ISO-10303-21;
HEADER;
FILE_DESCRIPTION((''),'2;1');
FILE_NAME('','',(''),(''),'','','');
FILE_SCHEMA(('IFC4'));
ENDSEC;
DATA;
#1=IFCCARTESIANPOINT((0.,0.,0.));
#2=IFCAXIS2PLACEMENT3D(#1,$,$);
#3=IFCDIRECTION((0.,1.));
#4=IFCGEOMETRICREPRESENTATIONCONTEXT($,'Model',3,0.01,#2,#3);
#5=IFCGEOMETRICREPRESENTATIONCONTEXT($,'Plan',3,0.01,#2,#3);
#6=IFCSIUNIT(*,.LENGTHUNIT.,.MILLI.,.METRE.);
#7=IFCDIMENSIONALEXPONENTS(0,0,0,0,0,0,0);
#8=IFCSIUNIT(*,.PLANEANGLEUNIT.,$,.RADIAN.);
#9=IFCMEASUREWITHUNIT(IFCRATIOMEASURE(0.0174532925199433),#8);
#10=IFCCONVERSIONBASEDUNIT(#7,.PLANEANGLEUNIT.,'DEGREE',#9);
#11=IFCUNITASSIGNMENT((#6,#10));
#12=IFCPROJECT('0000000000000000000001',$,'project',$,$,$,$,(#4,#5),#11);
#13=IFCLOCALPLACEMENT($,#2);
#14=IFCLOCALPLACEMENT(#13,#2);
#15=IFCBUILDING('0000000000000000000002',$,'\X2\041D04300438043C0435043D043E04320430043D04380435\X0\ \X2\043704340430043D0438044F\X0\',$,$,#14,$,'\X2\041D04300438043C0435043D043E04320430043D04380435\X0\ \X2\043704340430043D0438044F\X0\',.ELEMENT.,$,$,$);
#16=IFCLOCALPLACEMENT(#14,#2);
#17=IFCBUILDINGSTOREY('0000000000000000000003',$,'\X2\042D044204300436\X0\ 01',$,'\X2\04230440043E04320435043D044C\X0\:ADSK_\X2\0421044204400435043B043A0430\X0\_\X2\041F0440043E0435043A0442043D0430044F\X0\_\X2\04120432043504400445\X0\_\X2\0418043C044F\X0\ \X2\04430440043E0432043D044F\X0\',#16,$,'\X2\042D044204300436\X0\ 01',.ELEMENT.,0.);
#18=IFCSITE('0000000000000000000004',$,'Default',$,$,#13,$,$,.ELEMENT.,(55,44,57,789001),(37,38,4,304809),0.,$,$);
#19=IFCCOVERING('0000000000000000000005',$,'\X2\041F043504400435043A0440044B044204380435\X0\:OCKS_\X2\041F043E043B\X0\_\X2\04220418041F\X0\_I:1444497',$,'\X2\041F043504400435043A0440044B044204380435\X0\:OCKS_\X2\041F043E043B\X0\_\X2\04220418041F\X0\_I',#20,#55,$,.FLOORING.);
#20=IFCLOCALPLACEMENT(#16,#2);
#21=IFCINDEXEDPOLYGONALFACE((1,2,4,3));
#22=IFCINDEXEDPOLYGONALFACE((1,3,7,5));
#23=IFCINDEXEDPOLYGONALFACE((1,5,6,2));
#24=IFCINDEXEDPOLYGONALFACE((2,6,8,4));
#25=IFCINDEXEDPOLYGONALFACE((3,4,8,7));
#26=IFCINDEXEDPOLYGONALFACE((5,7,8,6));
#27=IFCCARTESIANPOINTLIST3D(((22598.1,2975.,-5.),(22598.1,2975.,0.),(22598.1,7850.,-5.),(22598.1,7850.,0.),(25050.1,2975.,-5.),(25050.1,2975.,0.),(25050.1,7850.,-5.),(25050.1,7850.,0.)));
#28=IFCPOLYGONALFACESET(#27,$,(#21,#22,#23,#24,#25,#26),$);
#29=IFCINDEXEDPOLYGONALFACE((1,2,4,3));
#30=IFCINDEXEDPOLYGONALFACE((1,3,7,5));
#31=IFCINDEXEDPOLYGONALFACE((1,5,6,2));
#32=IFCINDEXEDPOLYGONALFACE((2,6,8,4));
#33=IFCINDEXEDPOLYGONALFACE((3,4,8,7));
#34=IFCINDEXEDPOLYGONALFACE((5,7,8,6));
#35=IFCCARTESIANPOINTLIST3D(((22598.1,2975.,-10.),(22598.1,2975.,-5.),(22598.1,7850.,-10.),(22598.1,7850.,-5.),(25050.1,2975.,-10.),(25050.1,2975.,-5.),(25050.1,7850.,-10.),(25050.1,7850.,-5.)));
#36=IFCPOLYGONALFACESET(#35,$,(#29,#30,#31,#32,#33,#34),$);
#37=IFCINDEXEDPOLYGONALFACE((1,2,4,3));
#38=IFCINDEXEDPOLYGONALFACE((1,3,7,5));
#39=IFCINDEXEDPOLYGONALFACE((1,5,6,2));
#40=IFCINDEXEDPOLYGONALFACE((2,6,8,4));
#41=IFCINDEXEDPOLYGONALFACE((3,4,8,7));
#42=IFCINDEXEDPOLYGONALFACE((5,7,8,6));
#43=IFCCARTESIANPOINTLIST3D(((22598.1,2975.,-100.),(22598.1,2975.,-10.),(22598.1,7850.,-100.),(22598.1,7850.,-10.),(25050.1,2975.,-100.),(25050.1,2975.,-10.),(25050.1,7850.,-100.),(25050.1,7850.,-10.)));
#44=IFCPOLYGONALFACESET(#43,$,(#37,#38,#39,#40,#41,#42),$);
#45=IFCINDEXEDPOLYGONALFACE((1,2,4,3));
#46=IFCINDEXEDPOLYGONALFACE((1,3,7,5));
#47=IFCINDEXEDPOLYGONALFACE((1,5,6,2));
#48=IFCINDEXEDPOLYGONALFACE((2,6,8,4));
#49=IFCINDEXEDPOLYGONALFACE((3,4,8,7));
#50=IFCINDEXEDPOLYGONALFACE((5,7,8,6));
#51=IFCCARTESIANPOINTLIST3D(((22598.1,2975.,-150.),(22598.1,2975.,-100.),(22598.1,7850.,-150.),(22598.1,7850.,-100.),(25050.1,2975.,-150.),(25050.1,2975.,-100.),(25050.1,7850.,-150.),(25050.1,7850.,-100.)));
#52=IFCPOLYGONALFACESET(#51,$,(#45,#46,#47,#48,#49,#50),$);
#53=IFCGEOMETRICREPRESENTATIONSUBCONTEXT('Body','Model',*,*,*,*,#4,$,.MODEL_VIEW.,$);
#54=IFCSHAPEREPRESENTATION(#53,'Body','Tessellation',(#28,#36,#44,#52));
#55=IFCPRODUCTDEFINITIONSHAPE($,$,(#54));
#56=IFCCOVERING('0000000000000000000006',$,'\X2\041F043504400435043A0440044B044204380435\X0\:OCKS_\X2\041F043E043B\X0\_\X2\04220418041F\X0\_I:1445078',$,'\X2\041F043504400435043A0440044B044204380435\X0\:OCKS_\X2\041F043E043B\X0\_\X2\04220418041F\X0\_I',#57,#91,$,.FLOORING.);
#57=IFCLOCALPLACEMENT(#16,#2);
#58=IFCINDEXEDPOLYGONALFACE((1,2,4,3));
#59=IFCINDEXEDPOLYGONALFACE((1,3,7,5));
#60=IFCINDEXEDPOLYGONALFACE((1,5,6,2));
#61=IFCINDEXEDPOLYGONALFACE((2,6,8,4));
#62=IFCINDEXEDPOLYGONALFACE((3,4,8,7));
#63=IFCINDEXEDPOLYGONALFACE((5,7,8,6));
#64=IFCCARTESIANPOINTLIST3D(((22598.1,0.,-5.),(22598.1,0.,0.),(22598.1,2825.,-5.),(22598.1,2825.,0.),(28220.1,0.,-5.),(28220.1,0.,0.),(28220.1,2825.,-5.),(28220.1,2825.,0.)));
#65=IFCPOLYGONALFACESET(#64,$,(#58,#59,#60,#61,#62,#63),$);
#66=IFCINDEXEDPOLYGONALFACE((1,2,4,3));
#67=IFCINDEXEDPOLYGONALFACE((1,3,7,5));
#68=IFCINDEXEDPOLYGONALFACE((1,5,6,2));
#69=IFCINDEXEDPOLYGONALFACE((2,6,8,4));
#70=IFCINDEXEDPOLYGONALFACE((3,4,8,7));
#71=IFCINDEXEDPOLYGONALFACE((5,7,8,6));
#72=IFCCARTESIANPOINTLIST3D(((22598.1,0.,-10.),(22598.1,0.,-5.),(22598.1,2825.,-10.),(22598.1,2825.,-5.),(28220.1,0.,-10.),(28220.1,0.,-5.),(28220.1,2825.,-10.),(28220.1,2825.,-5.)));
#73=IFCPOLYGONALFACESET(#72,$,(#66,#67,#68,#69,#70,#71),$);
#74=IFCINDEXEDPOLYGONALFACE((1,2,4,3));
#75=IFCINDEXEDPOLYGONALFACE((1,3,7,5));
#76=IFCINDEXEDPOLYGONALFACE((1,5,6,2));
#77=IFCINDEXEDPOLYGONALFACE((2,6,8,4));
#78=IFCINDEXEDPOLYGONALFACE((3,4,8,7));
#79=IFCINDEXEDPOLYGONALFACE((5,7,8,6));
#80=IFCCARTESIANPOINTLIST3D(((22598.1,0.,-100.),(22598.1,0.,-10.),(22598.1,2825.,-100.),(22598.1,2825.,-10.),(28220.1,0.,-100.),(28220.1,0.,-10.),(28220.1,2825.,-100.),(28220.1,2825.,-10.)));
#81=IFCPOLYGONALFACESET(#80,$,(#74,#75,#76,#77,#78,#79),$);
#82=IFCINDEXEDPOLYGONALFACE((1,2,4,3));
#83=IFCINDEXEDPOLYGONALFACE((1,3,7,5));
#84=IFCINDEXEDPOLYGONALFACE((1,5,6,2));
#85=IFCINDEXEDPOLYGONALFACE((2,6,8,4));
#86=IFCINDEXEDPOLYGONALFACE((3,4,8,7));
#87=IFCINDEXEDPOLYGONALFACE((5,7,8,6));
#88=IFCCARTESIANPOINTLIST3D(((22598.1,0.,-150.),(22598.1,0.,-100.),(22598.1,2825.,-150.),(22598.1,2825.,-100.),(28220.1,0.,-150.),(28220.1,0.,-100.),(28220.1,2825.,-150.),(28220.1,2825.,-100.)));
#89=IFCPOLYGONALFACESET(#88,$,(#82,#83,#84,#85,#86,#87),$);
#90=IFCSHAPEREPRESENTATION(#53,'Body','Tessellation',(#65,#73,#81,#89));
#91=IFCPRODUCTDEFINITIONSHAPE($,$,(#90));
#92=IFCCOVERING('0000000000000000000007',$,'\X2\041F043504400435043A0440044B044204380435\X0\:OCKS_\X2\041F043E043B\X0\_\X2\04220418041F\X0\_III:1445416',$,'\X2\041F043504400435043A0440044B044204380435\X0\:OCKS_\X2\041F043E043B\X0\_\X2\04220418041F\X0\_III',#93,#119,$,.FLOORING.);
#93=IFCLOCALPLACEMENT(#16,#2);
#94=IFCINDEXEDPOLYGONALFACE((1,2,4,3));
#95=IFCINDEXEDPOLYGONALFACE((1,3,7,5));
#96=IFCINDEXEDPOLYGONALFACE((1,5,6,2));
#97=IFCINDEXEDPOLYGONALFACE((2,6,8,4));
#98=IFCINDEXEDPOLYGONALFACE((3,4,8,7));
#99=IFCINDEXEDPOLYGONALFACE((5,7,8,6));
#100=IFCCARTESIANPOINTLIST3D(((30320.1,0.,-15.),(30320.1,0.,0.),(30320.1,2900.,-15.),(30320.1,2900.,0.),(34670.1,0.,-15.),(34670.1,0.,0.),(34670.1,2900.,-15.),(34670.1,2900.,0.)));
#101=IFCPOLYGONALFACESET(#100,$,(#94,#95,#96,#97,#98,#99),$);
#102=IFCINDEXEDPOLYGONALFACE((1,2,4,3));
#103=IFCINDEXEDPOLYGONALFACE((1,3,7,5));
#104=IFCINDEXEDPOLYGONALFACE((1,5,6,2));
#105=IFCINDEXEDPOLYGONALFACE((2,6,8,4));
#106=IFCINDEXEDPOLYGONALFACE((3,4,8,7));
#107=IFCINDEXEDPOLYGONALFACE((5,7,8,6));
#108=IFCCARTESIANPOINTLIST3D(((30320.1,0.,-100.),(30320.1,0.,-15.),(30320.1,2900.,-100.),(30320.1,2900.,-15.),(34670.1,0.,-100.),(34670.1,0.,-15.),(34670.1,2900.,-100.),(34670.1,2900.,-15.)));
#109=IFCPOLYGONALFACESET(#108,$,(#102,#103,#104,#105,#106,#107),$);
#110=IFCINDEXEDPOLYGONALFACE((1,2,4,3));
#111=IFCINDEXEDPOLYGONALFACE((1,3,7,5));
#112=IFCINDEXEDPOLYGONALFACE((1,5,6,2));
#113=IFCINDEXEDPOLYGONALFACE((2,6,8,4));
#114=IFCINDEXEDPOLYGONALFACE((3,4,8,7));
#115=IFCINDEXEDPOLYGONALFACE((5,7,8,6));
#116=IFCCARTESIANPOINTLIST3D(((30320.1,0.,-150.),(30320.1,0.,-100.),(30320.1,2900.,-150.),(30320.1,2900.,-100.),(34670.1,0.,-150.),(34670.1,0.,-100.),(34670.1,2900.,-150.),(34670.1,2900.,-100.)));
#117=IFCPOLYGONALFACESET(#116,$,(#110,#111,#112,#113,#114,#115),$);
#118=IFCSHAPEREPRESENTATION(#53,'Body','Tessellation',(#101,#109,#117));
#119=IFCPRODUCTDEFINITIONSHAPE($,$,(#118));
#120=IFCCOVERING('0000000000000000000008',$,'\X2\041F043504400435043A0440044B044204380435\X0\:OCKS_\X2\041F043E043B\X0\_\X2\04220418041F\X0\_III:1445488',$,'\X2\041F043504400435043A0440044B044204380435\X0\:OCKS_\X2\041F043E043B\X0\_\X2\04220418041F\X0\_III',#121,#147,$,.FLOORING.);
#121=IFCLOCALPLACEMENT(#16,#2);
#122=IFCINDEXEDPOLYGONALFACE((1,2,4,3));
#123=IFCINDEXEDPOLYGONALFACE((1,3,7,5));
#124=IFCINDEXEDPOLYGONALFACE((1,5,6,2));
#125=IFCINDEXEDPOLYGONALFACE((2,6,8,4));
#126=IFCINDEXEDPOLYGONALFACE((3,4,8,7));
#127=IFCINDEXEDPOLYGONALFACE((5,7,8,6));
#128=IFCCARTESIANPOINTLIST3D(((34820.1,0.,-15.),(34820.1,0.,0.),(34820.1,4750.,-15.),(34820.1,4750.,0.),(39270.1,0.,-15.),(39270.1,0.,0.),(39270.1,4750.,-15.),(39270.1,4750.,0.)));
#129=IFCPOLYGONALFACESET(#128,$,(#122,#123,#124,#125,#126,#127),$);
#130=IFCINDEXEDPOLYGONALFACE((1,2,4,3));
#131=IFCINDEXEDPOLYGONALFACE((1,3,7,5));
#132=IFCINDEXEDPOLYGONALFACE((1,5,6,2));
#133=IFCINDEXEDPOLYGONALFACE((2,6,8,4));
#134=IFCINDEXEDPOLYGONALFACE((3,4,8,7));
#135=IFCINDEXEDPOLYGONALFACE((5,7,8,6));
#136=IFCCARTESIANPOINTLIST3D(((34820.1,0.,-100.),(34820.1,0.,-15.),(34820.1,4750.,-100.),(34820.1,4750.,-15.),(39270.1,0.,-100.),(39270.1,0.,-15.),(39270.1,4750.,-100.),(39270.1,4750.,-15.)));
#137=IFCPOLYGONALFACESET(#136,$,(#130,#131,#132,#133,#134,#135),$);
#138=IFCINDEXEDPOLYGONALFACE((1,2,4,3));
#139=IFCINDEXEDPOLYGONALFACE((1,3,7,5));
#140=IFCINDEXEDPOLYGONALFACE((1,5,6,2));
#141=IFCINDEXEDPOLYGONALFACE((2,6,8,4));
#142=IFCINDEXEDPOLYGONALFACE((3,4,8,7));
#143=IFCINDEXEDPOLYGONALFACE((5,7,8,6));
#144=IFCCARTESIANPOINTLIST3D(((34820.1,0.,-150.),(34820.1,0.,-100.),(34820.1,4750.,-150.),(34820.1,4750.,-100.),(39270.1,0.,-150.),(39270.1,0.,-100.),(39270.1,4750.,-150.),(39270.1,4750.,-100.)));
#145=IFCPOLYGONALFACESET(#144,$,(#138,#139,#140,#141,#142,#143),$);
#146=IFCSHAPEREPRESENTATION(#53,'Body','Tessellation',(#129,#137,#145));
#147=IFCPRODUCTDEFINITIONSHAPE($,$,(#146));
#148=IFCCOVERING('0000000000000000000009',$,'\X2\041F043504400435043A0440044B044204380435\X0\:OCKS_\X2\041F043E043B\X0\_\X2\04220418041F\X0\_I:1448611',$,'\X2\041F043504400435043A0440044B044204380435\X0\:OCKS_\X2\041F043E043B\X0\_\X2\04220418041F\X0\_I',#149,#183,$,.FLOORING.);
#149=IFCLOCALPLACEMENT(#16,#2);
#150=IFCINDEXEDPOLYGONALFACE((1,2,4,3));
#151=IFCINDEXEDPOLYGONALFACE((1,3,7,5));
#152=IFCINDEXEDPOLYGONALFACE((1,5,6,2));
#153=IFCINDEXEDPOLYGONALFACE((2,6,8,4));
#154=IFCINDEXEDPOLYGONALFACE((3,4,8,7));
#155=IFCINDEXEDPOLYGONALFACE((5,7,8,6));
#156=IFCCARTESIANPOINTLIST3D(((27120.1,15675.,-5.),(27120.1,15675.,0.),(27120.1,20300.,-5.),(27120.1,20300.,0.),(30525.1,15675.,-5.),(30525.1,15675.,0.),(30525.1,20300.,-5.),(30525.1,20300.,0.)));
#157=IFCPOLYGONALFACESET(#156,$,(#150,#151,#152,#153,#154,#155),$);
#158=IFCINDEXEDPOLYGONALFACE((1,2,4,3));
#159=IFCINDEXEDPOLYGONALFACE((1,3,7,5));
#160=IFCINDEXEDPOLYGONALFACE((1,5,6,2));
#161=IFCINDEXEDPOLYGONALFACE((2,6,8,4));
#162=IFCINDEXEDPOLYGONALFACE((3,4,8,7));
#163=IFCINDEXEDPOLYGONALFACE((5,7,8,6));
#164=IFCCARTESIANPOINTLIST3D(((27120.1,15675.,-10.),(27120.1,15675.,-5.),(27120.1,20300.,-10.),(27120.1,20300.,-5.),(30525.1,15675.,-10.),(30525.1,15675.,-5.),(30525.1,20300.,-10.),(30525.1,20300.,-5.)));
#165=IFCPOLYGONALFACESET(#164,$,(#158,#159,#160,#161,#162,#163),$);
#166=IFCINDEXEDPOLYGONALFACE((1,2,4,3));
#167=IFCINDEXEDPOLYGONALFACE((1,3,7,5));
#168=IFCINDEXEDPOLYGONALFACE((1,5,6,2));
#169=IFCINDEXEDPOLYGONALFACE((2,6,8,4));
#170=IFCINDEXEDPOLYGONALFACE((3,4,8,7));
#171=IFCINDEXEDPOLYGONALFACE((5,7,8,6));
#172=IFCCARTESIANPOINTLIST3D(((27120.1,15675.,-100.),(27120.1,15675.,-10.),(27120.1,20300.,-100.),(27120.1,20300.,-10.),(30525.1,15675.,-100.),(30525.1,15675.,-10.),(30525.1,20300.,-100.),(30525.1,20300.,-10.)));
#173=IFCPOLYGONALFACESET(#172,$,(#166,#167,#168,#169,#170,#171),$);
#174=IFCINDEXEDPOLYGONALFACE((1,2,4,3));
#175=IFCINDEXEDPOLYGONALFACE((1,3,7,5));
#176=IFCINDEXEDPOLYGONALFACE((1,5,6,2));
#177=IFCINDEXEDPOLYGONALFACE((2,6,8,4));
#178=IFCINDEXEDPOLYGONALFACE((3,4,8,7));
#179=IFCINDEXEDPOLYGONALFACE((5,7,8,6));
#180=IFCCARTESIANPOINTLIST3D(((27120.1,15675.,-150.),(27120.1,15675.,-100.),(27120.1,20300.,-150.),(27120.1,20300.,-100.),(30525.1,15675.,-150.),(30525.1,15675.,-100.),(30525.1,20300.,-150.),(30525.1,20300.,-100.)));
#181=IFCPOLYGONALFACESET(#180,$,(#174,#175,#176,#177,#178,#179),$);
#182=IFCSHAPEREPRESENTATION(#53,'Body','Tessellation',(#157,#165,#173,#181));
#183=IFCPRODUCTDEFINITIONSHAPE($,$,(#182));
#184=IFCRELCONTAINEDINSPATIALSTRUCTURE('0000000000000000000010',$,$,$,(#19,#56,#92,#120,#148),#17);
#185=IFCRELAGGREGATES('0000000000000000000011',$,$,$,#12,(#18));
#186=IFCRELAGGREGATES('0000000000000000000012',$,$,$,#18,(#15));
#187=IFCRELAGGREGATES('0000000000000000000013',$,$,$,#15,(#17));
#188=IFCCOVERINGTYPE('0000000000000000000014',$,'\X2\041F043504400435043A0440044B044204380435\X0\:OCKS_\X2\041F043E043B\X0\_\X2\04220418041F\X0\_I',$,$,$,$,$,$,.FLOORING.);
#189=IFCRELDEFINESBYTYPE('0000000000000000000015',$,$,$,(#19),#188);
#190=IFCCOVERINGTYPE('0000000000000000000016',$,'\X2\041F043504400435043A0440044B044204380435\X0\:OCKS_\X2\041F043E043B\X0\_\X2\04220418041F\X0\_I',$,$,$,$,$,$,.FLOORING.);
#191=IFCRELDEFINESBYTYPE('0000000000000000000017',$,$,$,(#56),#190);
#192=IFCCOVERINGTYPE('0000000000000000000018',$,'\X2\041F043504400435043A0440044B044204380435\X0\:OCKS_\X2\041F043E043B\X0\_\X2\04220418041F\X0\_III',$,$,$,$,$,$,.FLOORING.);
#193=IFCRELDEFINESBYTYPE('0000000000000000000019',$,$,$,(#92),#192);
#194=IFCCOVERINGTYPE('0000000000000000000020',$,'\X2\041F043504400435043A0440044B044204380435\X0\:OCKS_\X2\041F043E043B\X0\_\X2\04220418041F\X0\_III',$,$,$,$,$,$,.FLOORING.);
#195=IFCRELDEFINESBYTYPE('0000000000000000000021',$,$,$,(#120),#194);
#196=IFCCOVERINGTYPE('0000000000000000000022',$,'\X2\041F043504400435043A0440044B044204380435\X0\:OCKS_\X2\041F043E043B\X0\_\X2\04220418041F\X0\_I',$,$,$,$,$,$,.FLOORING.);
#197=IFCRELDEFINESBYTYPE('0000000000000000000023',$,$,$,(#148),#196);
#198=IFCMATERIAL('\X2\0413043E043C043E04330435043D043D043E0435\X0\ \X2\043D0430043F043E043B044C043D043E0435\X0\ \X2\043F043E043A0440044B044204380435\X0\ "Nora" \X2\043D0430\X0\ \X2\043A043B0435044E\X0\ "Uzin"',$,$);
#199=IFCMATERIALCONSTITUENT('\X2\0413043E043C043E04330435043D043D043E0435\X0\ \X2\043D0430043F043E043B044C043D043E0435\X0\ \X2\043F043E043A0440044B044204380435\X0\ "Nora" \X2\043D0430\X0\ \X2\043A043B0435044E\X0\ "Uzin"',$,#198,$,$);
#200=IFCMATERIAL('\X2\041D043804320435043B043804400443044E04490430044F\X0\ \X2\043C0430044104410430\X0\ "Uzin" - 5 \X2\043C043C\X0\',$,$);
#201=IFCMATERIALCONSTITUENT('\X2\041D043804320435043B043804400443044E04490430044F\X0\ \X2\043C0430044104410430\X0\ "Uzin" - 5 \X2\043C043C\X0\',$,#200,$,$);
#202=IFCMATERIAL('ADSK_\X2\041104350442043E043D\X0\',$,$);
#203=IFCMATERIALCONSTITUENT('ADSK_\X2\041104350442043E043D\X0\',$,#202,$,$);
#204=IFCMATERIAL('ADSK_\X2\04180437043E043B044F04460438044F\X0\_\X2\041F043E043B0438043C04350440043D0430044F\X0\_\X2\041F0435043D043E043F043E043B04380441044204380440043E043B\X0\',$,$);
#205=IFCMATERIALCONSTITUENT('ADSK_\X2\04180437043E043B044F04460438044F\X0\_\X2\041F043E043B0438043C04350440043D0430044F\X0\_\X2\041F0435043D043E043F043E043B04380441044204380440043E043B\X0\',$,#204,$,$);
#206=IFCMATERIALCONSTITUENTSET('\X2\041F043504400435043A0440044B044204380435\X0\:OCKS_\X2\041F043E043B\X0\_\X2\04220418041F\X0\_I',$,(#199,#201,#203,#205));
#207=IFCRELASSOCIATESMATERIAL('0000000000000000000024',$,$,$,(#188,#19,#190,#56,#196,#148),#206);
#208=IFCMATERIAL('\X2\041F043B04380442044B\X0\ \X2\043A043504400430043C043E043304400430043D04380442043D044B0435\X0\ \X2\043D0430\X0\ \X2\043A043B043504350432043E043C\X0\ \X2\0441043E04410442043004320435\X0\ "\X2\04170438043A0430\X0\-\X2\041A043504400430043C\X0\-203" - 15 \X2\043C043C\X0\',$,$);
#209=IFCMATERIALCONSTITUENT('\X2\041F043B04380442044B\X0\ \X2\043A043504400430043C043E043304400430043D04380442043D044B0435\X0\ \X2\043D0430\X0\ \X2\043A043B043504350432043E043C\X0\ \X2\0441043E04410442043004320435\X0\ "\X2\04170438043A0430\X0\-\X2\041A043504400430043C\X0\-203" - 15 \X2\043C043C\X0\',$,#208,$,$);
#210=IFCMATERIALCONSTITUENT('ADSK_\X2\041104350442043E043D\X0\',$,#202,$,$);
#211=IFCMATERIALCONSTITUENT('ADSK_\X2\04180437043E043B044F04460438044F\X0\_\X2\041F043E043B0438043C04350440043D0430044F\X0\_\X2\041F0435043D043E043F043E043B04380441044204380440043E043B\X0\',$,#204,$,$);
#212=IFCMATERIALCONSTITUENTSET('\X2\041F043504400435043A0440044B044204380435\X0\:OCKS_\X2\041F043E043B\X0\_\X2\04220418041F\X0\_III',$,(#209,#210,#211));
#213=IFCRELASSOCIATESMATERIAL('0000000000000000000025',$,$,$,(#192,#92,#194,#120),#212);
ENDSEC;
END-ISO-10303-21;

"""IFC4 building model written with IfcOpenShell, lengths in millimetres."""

from ifc_helpers import new_model, entity, si_unit, converted_unit, direction, frame, origin, place, context, subcontext, project, spatial, indexed_curve, outline, extrude, material, constituent, constituent_set, type_object, element, save


model = new_model("IFC4")

# Units and contexts
model_context = context("Model", 3, precision=0.01, world=origin(), true_north=direction((0.0, 1.0)))
plan_context = context("Plan", 3, precision=0.01, world=origin(), true_north=direction((0.0, 1.0)))
body_context = subcontext(model_context, "Body", "Model", "MODEL_VIEW")
ifc_project = project(units=[si_unit("LENGTHUNIT", "METRE", prefix="MILLI"), converted_unit("PLANEANGLEUNIT", "DEGREE", entity("IfcRatioMeasure", 0.0174532925199433), si_unit("PLANEANGLEUNIT", "RADIAN"), dimensions=[0, 0, 0, 0, 0, 0, 0])], contexts=[model_context, plan_context])

# Site, building, storey
site_placement = place(None, frame((0.0, 0.0, 0.0)))
site = spatial("IfcSite", under=ifc_project, at=site_placement, Name="Default", CompositionType="ELEMENT", RefLatitude=(55, 44, 57, 789001), RefLongitude=(37, 38, 4, 304809), RefElevation=0.0)
building_placement = place(site_placement, origin())
building = spatial("IfcBuilding", under=site, at=building_placement, Name="Наименование здания", LongName="Наименование здания", CompositionType="ELEMENT")
storey_placement = place(building_placement, origin())
storey = spatial("IfcBuildingStorey", under=building, at=storey_placement, Name="Этаж 01", ObjectType="Уровень:ADSK_Стрелка_Проектная_Вверх_Имя уровня", LongName="Этаж 01", CompositionType="ELEMENT", Elevation=0.0)

# Coverings
ifc_material_1 = material(Name="Плиты керамогранитные на клеевом составе \"Зика-Керам-203\" - 15 мм")
ifc_constituent_1 = constituent(ifc_material_1, Name="Плиты керамогранитные на клеевом составе \"Зика-Керам-203\" - 15 мм")
ifc_material_2 = material(Name="ADSK_Бетон")
ifc_constituent_2 = constituent(ifc_material_2, Name="ADSK_Бетон")
ifc_material_3 = material(Name="ADSK_Изоляция_Полимерная_Пенополистирол")
ifc_constituent_3 = constituent(ifc_material_3, Name="ADSK_Изоляция_Полимерная_Пенополистирол")
ifc_constituent_set_1 = constituent_set(constituents=[ifc_constituent_1, ifc_constituent_2, ifc_constituent_3], Name="Перекрытие:OCKS_Пол_ТИП_III")
ifc_material_4 = material(Name="Гомогенное напольное покрытие \"Nora\" на клею \"Uzin\"")
ifc_constituent_4 = constituent(ifc_material_4, Name="Гомогенное напольное покрытие \"Nora\" на клею \"Uzin\"")
ifc_material_5 = material(Name="Нивелирующая масса \"Uzin\" - 5 мм")
ifc_constituent_5 = constituent(ifc_material_5, Name="Нивелирующая масса \"Uzin\" - 5 мм")
ifc_constituent_6 = constituent(ifc_material_2, Name="ADSK_Бетон")
ifc_constituent_7 = constituent(ifc_material_3, Name="ADSK_Изоляция_Полимерная_Пенополистирол")
ifc_constituent_set_2 = constituent_set(constituents=[ifc_constituent_4, ifc_constituent_5, ifc_constituent_6, ifc_constituent_7], Name="Перекрытие:OCKS_Пол_ТИП_I")
covering_type_1 = type_object("IfcCoveringType", Name="Перекрытие:OCKS_Пол_ТИП_I", PredefinedType="FLOORING", material=ifc_constituent_set_2)
covering_1_placement = place(storey_placement, origin())
element("IfcCovering", 1, at=covering_1_placement, inside=storey, type_object=covering_type_1, material=ifc_constituent_set_2, Name="Перекрытие:OCKS_Пол_ТИП_I:1444497", ObjectType="Перекрытие:OCKS_Пол_ТИП_I", PredefinedType="FLOORING", context=body_context, shape_type="SweptSolid", body=[
    extrude(outline(indexed_curve([(-1226.0, -2437.5), (1226.0, -2437.5), (1226.0, 2437.5), (-1226.0, 2437.5), (-1226.0, -2437.5)], self_intersect=False)), frame((23824.1, 5412.5, -5.0), z_axis=(0.0, 0.0, 1.0), x_axis=(-1.0, 0.0, 0.0)), (0.0, 0.0, 1.0), 5.0),
    extrude(outline(indexed_curve([(-1226.0, -2437.5), (1226.0, -2437.5), (1226.0, 2437.5), (-1226.0, 2437.5), (-1226.0, -2437.5)], self_intersect=False)), frame((23824.1, 5412.5, -10.0), z_axis=(0.0, 0.0, 1.0), x_axis=(-1.0, 0.0, 0.0)), (0.0, 0.0, 1.0), 5.0),
    extrude(outline(indexed_curve([(-1226.0, -2437.5), (1226.0, -2437.5), (1226.0, 2437.5), (-1226.0, 2437.5), (-1226.0, -2437.5)], self_intersect=False)), frame((23824.1, 5412.5, -100.0), z_axis=(0.0, 0.0, 1.0), x_axis=(-1.0, 0.0, 0.0)), (0.0, 0.0, 1.0), 90.0),
    extrude(outline(indexed_curve([(-1226.0, -2437.5), (1226.0, -2437.5), (1226.0, 2437.5), (-1226.0, 2437.5), (-1226.0, -2437.5)], self_intersect=False)), frame((23824.1, 5412.5, -150.0), z_axis=(0.0, 0.0, 1.0), x_axis=(-1.0, 0.0, 0.0)), (0.0, 0.0, 1.0), 50.0),
])
covering_type_2 = type_object("IfcCoveringType", Name="Перекрытие:OCKS_Пол_ТИП_I", PredefinedType="FLOORING", material=ifc_constituent_set_2)
covering_2_placement = place(storey_placement, origin())
element("IfcCovering", 2, at=covering_2_placement, inside=storey, type_object=covering_type_2, material=ifc_constituent_set_2, Name="Перекрытие:OCKS_Пол_ТИП_I:1445078", ObjectType="Перекрытие:OCKS_Пол_ТИП_I", PredefinedType="FLOORING", context=body_context, shape_type="SweptSolid", body=[
    extrude(outline(indexed_curve([(-2811.0, -1412.5), (2811.0, -1412.5), (2811.0, 1412.5), (-2811.0, 1412.5), (-2811.0, -1412.5)], self_intersect=False)), frame((25409.1, 1412.5, -5.0), z_axis=(0.0, 0.0, 1.0), x_axis=(-1.0, 0.0, 0.0)), (0.0, 0.0, 1.0), 5.0),
    extrude(outline(indexed_curve([(-2811.0, -1412.5), (2811.0, -1412.5), (2811.0, 1412.5), (-2811.0, 1412.5), (-2811.0, -1412.5)], self_intersect=False)), frame((25409.1, 1412.5, -10.0), z_axis=(0.0, 0.0, 1.0), x_axis=(-1.0, 0.0, 0.0)), (0.0, 0.0, 1.0), 5.0),
    extrude(outline(indexed_curve([(-2811.0, -1412.5), (2811.0, -1412.5), (2811.0, 1412.5), (-2811.0, 1412.5), (-2811.0, -1412.5)], self_intersect=False)), frame((25409.1, 1412.5, -100.0), z_axis=(0.0, 0.0, 1.0), x_axis=(-1.0, 0.0, 0.0)), (0.0, 0.0, 1.0), 90.0),
    extrude(outline(indexed_curve([(-2811.0, -1412.5), (2811.0, -1412.5), (2811.0, 1412.5), (-2811.0, 1412.5), (-2811.0, -1412.5)], self_intersect=False)), frame((25409.1, 1412.5, -150.0), z_axis=(0.0, 0.0, 1.0), x_axis=(-1.0, 0.0, 0.0)), (0.0, 0.0, 1.0), 50.0),
])
covering_type_3 = type_object("IfcCoveringType", Name="Перекрытие:OCKS_Пол_ТИП_III", PredefinedType="FLOORING", material=ifc_constituent_set_1)
covering_3_placement = place(storey_placement, origin())
element("IfcCovering", 3, at=covering_3_placement, inside=storey, type_object=covering_type_3, material=ifc_constituent_set_1, Name="Перекрытие:OCKS_Пол_ТИП_III:1445416", ObjectType="Перекрытие:OCKS_Пол_ТИП_III", PredefinedType="FLOORING", context=body_context, shape_type="SweptSolid", body=[
    extrude(outline(indexed_curve([(-2175.0, -1450.0), (2175.0, -1450.0), (2175.0, 1450.0), (-2175.0, 1450.0), (-2175.0, -1450.0)], self_intersect=False)), frame((32495.1, 1450.0, -15.0), z_axis=(0.0, 0.0, 1.0), x_axis=(-1.0, 0.0, 0.0)), (0.0, 0.0, 1.0), 15.0),
    extrude(outline(indexed_curve([(-2175.0, -1450.0), (2175.0, -1450.0), (2175.0, 1450.0), (-2175.0, 1450.0), (-2175.0, -1450.0)], self_intersect=False)), frame((32495.1, 1450.0, -100.0), z_axis=(0.0, 0.0, 1.0), x_axis=(-1.0, 0.0, 0.0)), (0.0, 0.0, 1.0), 85.0),
    extrude(outline(indexed_curve([(-2175.0, -1450.0), (2175.0, -1450.0), (2175.0, 1450.0), (-2175.0, 1450.0), (-2175.0, -1450.0)], self_intersect=False)), frame((32495.1, 1450.0, -150.0), z_axis=(0.0, 0.0, 1.0), x_axis=(-1.0, 0.0, 0.0)), (0.0, 0.0, 1.0), 50.0),
])
covering_type_4 = type_object("IfcCoveringType", Name="Перекрытие:OCKS_Пол_ТИП_III", PredefinedType="FLOORING", material=ifc_constituent_set_1)
covering_4_placement = place(storey_placement, origin())
element("IfcCovering", 4, at=covering_4_placement, inside=storey, type_object=covering_type_4, material=ifc_constituent_set_1, Name="Перекрытие:OCKS_Пол_ТИП_III:1445488", ObjectType="Перекрытие:OCKS_Пол_ТИП_III", PredefinedType="FLOORING", context=body_context, shape_type="SweptSolid", body=[
    extrude(outline(indexed_curve([(-2225.0, -2375.0), (2225.0, -2375.0), (2225.0, 2375.0), (-2225.0, 2375.0), (-2225.0, -2375.0)], self_intersect=False)), frame((37045.1, 2375.0, -15.0), z_axis=(0.0, 0.0, 1.0), x_axis=(-1.0, 0.0, 0.0)), (0.0, 0.0, 1.0), 15.0),
    extrude(outline(indexed_curve([(-2225.0, -2375.0), (2225.0, -2375.0), (2225.0, 2375.0), (-2225.0, 2375.0), (-2225.0, -2375.0)], self_intersect=False)), frame((37045.1, 2375.0, -100.0), z_axis=(0.0, 0.0, 1.0), x_axis=(-1.0, 0.0, 0.0)), (0.0, 0.0, 1.0), 85.0),
    extrude(outline(indexed_curve([(-2225.0, -2375.0), (2225.0, -2375.0), (2225.0, 2375.0), (-2225.0, 2375.0), (-2225.0, -2375.0)], self_intersect=False)), frame((37045.1, 2375.0, -150.0), z_axis=(0.0, 0.0, 1.0), x_axis=(-1.0, 0.0, 0.0)), (0.0, 0.0, 1.0), 50.0),
])
covering_type_5 = type_object("IfcCoveringType", Name="Перекрытие:OCKS_Пол_ТИП_I", PredefinedType="FLOORING", material=ifc_constituent_set_2)
covering_5_placement = place(storey_placement, origin())
element("IfcCovering", 5, at=covering_5_placement, inside=storey, type_object=covering_type_5, material=ifc_constituent_set_2, Name="Перекрытие:OCKS_Пол_ТИП_I:1448611", ObjectType="Перекрытие:OCKS_Пол_ТИП_I", PredefinedType="FLOORING", context=body_context, shape_type="SweptSolid", body=[
    extrude(outline(indexed_curve([(-1702.5, -2312.5), (1702.5, -2312.5), (1702.5, 2312.5), (-1702.5, 2312.5), (-1702.5, -2312.5)], self_intersect=False)), frame((28822.6, 17987.5, -5.0), z_axis=(0.0, 0.0, 1.0), x_axis=(-1.0, 0.0, 0.0)), (0.0, 0.0, 1.0), 5.0),
    extrude(outline(indexed_curve([(-1702.5, -2312.5), (1702.5, -2312.5), (1702.5, 2312.5), (-1702.5, 2312.5), (-1702.5, -2312.5)], self_intersect=False)), frame((28822.6, 17987.5, -10.0), z_axis=(0.0, 0.0, 1.0), x_axis=(-1.0, 0.0, 0.0)), (0.0, 0.0, 1.0), 5.0),
    extrude(outline(indexed_curve([(-1702.5, -2312.5), (1702.5, -2312.5), (1702.5, 2312.5), (-1702.5, 2312.5), (-1702.5, -2312.5)], self_intersect=False)), frame((28822.6, 17987.5, -100.0), z_axis=(0.0, 0.0, 1.0), x_axis=(-1.0, 0.0, 0.0)), (0.0, 0.0, 1.0), 90.0),
    extrude(outline(indexed_curve([(-1702.5, -2312.5), (1702.5, -2312.5), (1702.5, 2312.5), (-1702.5, 2312.5), (-1702.5, -2312.5)], self_intersect=False)), frame((28822.6, 17987.5, -150.0), z_axis=(0.0, 0.0, 1.0), x_axis=(-1.0, 0.0, 0.0)), (0.0, 0.0, 1.0), 50.0),
])

save(model, "model.ifc")
